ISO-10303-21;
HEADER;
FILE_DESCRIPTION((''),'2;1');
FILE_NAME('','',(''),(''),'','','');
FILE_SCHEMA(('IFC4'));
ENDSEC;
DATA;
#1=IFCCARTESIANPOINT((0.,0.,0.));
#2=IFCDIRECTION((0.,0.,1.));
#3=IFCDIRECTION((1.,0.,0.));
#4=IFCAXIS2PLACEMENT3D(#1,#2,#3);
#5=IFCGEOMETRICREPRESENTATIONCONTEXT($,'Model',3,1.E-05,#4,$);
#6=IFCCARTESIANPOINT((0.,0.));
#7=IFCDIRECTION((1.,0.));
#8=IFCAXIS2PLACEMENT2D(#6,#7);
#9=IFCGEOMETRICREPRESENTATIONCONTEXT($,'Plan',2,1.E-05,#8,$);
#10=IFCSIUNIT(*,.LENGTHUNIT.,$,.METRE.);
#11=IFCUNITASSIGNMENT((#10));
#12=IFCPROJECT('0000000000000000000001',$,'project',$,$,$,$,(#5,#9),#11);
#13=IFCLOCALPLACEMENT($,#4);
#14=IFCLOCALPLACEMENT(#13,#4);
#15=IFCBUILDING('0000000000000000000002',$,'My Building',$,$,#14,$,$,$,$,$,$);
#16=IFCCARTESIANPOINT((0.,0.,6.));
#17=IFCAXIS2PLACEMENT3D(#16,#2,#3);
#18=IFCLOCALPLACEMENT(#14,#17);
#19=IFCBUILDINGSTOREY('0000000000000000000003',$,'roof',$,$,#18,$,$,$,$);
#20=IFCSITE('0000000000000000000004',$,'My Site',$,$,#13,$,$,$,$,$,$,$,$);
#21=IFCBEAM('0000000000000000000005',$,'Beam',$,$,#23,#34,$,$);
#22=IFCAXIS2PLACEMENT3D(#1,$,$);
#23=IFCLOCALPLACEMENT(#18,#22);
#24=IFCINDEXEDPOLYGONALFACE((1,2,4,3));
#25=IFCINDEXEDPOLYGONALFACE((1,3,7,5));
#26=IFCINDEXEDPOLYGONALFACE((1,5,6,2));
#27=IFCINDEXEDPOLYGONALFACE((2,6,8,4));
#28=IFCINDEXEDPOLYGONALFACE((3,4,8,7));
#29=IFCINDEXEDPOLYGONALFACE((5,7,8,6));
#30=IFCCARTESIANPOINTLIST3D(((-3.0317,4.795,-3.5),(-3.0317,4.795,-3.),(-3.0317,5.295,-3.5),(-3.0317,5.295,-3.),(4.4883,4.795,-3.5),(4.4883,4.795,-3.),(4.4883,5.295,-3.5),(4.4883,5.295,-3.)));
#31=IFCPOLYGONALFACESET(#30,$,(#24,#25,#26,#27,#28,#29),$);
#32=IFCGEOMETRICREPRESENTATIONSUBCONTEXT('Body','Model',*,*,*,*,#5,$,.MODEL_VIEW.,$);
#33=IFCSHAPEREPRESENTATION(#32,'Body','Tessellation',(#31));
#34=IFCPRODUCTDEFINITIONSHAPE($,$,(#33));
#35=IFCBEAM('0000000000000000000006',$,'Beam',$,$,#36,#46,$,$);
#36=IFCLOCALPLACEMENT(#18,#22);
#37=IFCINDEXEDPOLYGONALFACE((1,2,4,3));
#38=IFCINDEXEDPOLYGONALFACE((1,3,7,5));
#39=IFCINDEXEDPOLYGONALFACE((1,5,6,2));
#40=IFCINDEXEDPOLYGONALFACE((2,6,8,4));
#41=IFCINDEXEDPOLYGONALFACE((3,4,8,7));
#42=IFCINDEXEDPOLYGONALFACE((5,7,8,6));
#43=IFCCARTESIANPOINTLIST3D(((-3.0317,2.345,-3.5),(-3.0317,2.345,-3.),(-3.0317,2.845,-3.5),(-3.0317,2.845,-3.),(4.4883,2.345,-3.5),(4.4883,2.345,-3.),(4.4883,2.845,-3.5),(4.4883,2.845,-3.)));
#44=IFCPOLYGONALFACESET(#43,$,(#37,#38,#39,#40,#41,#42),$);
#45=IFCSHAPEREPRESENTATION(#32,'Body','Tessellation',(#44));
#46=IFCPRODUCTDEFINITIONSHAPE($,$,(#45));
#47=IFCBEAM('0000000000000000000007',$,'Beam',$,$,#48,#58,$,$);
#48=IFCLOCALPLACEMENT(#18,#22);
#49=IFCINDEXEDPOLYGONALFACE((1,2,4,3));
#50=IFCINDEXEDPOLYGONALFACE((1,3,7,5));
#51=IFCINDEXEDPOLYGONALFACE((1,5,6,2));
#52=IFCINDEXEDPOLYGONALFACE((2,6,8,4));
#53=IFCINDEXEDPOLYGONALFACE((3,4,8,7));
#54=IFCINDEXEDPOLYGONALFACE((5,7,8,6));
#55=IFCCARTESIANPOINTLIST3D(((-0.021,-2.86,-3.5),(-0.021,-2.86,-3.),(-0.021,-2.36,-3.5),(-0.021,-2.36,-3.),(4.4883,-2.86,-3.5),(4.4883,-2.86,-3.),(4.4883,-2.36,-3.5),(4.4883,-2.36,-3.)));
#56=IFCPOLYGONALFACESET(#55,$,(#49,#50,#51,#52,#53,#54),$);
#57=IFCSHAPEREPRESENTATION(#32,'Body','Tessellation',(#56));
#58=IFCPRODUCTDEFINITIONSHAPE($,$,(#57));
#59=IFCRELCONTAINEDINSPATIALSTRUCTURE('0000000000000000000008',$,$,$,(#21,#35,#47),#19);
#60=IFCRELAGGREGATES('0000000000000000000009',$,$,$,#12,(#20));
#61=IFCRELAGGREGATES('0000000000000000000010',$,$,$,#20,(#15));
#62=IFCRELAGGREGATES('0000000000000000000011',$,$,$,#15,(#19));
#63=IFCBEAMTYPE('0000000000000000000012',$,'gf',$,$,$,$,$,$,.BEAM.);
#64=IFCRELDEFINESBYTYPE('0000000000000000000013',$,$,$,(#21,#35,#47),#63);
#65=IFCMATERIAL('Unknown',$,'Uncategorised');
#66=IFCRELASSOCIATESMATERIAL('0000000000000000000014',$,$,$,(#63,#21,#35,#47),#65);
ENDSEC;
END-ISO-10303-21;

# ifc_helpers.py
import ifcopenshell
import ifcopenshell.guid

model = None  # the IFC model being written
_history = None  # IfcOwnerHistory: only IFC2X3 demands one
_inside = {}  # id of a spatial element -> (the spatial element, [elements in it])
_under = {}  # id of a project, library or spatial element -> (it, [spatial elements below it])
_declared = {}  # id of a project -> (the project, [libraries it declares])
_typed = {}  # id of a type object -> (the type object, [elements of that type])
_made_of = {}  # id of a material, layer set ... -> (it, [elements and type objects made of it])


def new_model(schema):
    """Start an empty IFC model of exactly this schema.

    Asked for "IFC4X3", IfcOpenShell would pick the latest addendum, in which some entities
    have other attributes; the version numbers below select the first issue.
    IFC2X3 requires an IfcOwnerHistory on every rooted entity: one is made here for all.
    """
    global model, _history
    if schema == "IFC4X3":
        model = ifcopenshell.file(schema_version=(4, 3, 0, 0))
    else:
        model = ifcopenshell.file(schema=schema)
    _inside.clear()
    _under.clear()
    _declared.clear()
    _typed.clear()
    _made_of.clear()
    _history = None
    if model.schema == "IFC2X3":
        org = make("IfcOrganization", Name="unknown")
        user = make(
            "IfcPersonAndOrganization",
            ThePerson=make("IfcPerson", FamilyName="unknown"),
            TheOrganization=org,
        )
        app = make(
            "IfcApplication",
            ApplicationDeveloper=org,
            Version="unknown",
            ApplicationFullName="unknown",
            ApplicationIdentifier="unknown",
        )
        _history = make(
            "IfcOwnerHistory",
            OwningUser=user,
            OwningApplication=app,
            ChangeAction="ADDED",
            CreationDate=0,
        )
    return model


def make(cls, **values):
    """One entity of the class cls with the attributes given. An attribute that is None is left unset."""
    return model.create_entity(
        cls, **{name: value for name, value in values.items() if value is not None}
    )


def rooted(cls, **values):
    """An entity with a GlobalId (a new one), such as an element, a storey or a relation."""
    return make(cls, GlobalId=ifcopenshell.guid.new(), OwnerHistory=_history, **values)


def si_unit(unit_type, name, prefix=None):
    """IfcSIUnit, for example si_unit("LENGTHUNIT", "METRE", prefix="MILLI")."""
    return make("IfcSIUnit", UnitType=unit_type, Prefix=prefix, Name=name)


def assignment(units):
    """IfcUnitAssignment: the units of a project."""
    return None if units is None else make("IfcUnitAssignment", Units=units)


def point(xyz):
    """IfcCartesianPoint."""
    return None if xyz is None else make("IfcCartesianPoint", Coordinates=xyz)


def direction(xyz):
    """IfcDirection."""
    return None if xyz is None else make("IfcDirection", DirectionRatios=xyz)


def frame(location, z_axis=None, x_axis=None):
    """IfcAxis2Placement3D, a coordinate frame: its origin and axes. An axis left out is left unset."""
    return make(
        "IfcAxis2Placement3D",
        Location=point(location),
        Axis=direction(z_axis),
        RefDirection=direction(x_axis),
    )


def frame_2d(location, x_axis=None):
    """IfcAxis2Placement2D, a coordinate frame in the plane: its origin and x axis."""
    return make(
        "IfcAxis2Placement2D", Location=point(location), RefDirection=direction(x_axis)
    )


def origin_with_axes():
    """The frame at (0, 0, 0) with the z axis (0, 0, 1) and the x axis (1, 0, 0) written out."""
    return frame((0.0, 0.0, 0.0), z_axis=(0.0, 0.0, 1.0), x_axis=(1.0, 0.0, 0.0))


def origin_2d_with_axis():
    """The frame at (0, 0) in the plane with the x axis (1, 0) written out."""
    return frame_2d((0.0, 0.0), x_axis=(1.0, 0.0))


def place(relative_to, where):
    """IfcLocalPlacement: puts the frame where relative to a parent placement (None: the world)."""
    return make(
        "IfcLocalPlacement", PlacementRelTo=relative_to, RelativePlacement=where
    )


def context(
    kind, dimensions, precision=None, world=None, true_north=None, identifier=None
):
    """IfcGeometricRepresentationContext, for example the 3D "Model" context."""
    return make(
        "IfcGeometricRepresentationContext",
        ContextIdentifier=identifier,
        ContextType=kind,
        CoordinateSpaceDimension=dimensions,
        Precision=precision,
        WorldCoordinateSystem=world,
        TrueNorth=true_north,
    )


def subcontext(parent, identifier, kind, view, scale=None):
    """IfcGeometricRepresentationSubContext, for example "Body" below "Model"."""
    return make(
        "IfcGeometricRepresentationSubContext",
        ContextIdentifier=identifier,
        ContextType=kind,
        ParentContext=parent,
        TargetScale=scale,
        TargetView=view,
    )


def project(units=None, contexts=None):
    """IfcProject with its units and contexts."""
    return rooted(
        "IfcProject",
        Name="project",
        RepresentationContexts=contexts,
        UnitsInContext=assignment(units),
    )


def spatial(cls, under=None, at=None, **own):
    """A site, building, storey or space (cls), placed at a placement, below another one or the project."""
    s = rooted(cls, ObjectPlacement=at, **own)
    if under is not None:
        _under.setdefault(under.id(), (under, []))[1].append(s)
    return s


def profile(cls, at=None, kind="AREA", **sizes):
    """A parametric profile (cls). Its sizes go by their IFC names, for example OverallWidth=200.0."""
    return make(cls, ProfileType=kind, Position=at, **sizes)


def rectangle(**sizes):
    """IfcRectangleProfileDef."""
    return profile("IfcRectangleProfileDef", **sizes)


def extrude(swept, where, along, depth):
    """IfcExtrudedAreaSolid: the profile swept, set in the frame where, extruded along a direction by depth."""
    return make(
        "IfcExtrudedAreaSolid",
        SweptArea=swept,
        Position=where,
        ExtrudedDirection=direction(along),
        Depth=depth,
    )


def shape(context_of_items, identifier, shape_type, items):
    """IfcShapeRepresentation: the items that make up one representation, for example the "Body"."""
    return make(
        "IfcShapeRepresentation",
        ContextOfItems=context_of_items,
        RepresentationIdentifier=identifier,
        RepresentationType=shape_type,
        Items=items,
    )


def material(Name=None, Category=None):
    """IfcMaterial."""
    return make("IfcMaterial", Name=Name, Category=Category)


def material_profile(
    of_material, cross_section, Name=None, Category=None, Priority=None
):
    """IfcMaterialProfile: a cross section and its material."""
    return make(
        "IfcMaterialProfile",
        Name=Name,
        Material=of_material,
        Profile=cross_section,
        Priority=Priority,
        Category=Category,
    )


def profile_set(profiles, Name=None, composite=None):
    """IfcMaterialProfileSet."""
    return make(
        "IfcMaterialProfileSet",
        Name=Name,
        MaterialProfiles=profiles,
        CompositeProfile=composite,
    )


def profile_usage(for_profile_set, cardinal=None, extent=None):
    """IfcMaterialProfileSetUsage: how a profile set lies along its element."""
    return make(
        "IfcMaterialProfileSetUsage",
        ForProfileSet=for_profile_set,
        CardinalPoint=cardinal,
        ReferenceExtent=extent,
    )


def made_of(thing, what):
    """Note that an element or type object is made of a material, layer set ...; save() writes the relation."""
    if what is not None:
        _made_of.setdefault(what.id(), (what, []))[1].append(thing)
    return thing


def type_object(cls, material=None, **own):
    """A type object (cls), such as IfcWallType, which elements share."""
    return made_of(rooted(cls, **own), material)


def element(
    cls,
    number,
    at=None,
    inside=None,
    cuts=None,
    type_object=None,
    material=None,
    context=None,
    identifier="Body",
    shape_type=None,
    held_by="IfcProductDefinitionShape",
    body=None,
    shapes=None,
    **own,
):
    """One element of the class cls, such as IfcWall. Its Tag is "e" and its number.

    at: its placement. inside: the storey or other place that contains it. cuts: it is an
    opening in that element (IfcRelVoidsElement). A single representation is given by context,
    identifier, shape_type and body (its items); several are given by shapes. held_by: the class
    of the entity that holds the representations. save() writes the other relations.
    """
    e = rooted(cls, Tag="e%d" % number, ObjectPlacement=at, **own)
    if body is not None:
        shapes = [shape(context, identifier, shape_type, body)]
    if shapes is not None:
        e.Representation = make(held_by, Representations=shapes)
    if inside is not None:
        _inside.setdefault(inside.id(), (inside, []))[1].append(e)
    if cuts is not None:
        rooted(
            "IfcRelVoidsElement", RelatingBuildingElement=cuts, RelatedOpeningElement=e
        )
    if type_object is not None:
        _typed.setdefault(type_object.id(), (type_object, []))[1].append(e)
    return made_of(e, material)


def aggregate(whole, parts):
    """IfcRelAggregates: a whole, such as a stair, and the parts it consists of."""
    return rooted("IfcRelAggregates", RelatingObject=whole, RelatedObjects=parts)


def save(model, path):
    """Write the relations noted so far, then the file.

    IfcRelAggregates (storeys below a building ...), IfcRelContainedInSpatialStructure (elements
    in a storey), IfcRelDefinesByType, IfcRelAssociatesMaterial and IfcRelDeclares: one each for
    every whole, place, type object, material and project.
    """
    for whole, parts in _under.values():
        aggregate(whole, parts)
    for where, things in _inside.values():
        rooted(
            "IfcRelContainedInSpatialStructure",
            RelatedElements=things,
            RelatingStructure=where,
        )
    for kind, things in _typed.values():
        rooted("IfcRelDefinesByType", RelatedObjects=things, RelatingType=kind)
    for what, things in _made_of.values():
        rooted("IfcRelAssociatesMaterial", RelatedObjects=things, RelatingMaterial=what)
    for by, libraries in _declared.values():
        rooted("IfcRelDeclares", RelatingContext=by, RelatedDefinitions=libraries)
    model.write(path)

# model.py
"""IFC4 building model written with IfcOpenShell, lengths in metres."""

from ifc_helpers import new_model, si_unit, frame, origin_with_axes, origin_2d_with_axis, place, context, subcontext, project, spatial, rectangle, extrude, material, material_profile, profile_set, profile_usage, type_object, element, save


model = new_model("IFC4")

# Units and contexts
model_context = context("Model", 3, precision=1e-05, world=origin_with_axes())
plan_context = context("Plan", 2, precision=1e-05, world=origin_2d_with_axis())
body_context = subcontext(model_context, "Body", "Model", "MODEL_VIEW")
ifc_project = project(units=[si_unit("LENGTHUNIT", "METRE")], contexts=[model_context, plan_context])

# Site, building, storey
site_placement = place(None, origin_with_axes())
site = spatial("IfcSite", under=ifc_project, at=site_placement, Name="My Site")
building_placement = place(site_placement, origin_with_axes())
building = spatial("IfcBuilding", under=site, at=building_placement, Name="My Building")
storey_placement = place(building_placement, frame((0.0, 0.0, 6.0), z_axis=(0.0, 0.0, 1.0), x_axis=(1.0, 0.0, 0.0)))
storey = spatial("IfcBuildingStorey", under=building, at=storey_placement, Name="roof")

# Shared definitions
ifc_material = material(Name="Unknown", Category="Uncategorised")

# Beams
ifc_material_profile_1 = material_profile(ifc_material, rectangle(XDim=0.5, YDim=0.5))
ifc_profile_set_1 = profile_set([ifc_material_profile_1])
beam_type = type_object("IfcBeamType", Name="gf", PredefinedType="BEAM", material=ifc_profile_set_1)
ifc_profile_usage_1 = profile_usage(ifc_profile_set_1, cardinal=7)
beam_1_placement = place(storey_placement, frame((-3.0317, 5.295, -3.0), z_axis=(1.0, 0.0, 0.0), x_axis=(0.0, 1.0, 0.0)))
element("IfcBeam", 1, at=beam_1_placement, inside=storey, type_object=beam_type, material=ifc_profile_usage_1, Name="Beam", context=body_context, shape_type="SweptSolid", body=[
    extrude(rectangle(XDim=0.5, YDim=0.5), frame((-0.25, -0.25, 0.0), z_axis=(0.0, 0.0, 1.0), x_axis=(1.0, 0.0, 0.0)), (0.0, 0.0, 1.0), 7.52),
])
ifc_profile_usage_2 = profile_usage(ifc_profile_set_1, cardinal=7)
beam_2_placement = place(storey_placement, frame((4.4883, 2.345, -3.0), z_axis=(-1.0, 0.0, 0.0), x_axis=(0.0, -1.0, 0.0)))
element("IfcBeam", 2, at=beam_2_placement, inside=storey, type_object=beam_type, material=ifc_profile_usage_2, Name="Beam", context=body_context, shape_type="SweptSolid", body=[
    extrude(rectangle(XDim=0.5, YDim=0.5), frame((-0.25, -0.25, 0.0), z_axis=(0.0, 0.0, 1.0), x_axis=(1.0, 0.0, 0.0)), (0.0, 0.0, 1.0), 7.52),
])
ifc_profile_usage_3 = profile_usage(ifc_profile_set_1, cardinal=7)
beam_3_placement = place(storey_placement, frame((4.4883, -2.86, -3.0), z_axis=(-1.0, 0.0, 0.0), x_axis=(0.0, -1.0, 0.0)))
element("IfcBeam", 3, at=beam_3_placement, inside=storey, type_object=beam_type, material=ifc_profile_usage_3, Name="Beam", context=body_context, shape_type="SweptSolid", body=[
    extrude(rectangle(XDim=0.5, YDim=0.5), frame((-0.25, -0.25, 0.0), z_axis=(0.0, 0.0, 1.0), x_axis=(1.0, 0.0, 0.0)), (0.0, 0.0, 1.0), 4.5094),
])

save(model, "model.ifc")
